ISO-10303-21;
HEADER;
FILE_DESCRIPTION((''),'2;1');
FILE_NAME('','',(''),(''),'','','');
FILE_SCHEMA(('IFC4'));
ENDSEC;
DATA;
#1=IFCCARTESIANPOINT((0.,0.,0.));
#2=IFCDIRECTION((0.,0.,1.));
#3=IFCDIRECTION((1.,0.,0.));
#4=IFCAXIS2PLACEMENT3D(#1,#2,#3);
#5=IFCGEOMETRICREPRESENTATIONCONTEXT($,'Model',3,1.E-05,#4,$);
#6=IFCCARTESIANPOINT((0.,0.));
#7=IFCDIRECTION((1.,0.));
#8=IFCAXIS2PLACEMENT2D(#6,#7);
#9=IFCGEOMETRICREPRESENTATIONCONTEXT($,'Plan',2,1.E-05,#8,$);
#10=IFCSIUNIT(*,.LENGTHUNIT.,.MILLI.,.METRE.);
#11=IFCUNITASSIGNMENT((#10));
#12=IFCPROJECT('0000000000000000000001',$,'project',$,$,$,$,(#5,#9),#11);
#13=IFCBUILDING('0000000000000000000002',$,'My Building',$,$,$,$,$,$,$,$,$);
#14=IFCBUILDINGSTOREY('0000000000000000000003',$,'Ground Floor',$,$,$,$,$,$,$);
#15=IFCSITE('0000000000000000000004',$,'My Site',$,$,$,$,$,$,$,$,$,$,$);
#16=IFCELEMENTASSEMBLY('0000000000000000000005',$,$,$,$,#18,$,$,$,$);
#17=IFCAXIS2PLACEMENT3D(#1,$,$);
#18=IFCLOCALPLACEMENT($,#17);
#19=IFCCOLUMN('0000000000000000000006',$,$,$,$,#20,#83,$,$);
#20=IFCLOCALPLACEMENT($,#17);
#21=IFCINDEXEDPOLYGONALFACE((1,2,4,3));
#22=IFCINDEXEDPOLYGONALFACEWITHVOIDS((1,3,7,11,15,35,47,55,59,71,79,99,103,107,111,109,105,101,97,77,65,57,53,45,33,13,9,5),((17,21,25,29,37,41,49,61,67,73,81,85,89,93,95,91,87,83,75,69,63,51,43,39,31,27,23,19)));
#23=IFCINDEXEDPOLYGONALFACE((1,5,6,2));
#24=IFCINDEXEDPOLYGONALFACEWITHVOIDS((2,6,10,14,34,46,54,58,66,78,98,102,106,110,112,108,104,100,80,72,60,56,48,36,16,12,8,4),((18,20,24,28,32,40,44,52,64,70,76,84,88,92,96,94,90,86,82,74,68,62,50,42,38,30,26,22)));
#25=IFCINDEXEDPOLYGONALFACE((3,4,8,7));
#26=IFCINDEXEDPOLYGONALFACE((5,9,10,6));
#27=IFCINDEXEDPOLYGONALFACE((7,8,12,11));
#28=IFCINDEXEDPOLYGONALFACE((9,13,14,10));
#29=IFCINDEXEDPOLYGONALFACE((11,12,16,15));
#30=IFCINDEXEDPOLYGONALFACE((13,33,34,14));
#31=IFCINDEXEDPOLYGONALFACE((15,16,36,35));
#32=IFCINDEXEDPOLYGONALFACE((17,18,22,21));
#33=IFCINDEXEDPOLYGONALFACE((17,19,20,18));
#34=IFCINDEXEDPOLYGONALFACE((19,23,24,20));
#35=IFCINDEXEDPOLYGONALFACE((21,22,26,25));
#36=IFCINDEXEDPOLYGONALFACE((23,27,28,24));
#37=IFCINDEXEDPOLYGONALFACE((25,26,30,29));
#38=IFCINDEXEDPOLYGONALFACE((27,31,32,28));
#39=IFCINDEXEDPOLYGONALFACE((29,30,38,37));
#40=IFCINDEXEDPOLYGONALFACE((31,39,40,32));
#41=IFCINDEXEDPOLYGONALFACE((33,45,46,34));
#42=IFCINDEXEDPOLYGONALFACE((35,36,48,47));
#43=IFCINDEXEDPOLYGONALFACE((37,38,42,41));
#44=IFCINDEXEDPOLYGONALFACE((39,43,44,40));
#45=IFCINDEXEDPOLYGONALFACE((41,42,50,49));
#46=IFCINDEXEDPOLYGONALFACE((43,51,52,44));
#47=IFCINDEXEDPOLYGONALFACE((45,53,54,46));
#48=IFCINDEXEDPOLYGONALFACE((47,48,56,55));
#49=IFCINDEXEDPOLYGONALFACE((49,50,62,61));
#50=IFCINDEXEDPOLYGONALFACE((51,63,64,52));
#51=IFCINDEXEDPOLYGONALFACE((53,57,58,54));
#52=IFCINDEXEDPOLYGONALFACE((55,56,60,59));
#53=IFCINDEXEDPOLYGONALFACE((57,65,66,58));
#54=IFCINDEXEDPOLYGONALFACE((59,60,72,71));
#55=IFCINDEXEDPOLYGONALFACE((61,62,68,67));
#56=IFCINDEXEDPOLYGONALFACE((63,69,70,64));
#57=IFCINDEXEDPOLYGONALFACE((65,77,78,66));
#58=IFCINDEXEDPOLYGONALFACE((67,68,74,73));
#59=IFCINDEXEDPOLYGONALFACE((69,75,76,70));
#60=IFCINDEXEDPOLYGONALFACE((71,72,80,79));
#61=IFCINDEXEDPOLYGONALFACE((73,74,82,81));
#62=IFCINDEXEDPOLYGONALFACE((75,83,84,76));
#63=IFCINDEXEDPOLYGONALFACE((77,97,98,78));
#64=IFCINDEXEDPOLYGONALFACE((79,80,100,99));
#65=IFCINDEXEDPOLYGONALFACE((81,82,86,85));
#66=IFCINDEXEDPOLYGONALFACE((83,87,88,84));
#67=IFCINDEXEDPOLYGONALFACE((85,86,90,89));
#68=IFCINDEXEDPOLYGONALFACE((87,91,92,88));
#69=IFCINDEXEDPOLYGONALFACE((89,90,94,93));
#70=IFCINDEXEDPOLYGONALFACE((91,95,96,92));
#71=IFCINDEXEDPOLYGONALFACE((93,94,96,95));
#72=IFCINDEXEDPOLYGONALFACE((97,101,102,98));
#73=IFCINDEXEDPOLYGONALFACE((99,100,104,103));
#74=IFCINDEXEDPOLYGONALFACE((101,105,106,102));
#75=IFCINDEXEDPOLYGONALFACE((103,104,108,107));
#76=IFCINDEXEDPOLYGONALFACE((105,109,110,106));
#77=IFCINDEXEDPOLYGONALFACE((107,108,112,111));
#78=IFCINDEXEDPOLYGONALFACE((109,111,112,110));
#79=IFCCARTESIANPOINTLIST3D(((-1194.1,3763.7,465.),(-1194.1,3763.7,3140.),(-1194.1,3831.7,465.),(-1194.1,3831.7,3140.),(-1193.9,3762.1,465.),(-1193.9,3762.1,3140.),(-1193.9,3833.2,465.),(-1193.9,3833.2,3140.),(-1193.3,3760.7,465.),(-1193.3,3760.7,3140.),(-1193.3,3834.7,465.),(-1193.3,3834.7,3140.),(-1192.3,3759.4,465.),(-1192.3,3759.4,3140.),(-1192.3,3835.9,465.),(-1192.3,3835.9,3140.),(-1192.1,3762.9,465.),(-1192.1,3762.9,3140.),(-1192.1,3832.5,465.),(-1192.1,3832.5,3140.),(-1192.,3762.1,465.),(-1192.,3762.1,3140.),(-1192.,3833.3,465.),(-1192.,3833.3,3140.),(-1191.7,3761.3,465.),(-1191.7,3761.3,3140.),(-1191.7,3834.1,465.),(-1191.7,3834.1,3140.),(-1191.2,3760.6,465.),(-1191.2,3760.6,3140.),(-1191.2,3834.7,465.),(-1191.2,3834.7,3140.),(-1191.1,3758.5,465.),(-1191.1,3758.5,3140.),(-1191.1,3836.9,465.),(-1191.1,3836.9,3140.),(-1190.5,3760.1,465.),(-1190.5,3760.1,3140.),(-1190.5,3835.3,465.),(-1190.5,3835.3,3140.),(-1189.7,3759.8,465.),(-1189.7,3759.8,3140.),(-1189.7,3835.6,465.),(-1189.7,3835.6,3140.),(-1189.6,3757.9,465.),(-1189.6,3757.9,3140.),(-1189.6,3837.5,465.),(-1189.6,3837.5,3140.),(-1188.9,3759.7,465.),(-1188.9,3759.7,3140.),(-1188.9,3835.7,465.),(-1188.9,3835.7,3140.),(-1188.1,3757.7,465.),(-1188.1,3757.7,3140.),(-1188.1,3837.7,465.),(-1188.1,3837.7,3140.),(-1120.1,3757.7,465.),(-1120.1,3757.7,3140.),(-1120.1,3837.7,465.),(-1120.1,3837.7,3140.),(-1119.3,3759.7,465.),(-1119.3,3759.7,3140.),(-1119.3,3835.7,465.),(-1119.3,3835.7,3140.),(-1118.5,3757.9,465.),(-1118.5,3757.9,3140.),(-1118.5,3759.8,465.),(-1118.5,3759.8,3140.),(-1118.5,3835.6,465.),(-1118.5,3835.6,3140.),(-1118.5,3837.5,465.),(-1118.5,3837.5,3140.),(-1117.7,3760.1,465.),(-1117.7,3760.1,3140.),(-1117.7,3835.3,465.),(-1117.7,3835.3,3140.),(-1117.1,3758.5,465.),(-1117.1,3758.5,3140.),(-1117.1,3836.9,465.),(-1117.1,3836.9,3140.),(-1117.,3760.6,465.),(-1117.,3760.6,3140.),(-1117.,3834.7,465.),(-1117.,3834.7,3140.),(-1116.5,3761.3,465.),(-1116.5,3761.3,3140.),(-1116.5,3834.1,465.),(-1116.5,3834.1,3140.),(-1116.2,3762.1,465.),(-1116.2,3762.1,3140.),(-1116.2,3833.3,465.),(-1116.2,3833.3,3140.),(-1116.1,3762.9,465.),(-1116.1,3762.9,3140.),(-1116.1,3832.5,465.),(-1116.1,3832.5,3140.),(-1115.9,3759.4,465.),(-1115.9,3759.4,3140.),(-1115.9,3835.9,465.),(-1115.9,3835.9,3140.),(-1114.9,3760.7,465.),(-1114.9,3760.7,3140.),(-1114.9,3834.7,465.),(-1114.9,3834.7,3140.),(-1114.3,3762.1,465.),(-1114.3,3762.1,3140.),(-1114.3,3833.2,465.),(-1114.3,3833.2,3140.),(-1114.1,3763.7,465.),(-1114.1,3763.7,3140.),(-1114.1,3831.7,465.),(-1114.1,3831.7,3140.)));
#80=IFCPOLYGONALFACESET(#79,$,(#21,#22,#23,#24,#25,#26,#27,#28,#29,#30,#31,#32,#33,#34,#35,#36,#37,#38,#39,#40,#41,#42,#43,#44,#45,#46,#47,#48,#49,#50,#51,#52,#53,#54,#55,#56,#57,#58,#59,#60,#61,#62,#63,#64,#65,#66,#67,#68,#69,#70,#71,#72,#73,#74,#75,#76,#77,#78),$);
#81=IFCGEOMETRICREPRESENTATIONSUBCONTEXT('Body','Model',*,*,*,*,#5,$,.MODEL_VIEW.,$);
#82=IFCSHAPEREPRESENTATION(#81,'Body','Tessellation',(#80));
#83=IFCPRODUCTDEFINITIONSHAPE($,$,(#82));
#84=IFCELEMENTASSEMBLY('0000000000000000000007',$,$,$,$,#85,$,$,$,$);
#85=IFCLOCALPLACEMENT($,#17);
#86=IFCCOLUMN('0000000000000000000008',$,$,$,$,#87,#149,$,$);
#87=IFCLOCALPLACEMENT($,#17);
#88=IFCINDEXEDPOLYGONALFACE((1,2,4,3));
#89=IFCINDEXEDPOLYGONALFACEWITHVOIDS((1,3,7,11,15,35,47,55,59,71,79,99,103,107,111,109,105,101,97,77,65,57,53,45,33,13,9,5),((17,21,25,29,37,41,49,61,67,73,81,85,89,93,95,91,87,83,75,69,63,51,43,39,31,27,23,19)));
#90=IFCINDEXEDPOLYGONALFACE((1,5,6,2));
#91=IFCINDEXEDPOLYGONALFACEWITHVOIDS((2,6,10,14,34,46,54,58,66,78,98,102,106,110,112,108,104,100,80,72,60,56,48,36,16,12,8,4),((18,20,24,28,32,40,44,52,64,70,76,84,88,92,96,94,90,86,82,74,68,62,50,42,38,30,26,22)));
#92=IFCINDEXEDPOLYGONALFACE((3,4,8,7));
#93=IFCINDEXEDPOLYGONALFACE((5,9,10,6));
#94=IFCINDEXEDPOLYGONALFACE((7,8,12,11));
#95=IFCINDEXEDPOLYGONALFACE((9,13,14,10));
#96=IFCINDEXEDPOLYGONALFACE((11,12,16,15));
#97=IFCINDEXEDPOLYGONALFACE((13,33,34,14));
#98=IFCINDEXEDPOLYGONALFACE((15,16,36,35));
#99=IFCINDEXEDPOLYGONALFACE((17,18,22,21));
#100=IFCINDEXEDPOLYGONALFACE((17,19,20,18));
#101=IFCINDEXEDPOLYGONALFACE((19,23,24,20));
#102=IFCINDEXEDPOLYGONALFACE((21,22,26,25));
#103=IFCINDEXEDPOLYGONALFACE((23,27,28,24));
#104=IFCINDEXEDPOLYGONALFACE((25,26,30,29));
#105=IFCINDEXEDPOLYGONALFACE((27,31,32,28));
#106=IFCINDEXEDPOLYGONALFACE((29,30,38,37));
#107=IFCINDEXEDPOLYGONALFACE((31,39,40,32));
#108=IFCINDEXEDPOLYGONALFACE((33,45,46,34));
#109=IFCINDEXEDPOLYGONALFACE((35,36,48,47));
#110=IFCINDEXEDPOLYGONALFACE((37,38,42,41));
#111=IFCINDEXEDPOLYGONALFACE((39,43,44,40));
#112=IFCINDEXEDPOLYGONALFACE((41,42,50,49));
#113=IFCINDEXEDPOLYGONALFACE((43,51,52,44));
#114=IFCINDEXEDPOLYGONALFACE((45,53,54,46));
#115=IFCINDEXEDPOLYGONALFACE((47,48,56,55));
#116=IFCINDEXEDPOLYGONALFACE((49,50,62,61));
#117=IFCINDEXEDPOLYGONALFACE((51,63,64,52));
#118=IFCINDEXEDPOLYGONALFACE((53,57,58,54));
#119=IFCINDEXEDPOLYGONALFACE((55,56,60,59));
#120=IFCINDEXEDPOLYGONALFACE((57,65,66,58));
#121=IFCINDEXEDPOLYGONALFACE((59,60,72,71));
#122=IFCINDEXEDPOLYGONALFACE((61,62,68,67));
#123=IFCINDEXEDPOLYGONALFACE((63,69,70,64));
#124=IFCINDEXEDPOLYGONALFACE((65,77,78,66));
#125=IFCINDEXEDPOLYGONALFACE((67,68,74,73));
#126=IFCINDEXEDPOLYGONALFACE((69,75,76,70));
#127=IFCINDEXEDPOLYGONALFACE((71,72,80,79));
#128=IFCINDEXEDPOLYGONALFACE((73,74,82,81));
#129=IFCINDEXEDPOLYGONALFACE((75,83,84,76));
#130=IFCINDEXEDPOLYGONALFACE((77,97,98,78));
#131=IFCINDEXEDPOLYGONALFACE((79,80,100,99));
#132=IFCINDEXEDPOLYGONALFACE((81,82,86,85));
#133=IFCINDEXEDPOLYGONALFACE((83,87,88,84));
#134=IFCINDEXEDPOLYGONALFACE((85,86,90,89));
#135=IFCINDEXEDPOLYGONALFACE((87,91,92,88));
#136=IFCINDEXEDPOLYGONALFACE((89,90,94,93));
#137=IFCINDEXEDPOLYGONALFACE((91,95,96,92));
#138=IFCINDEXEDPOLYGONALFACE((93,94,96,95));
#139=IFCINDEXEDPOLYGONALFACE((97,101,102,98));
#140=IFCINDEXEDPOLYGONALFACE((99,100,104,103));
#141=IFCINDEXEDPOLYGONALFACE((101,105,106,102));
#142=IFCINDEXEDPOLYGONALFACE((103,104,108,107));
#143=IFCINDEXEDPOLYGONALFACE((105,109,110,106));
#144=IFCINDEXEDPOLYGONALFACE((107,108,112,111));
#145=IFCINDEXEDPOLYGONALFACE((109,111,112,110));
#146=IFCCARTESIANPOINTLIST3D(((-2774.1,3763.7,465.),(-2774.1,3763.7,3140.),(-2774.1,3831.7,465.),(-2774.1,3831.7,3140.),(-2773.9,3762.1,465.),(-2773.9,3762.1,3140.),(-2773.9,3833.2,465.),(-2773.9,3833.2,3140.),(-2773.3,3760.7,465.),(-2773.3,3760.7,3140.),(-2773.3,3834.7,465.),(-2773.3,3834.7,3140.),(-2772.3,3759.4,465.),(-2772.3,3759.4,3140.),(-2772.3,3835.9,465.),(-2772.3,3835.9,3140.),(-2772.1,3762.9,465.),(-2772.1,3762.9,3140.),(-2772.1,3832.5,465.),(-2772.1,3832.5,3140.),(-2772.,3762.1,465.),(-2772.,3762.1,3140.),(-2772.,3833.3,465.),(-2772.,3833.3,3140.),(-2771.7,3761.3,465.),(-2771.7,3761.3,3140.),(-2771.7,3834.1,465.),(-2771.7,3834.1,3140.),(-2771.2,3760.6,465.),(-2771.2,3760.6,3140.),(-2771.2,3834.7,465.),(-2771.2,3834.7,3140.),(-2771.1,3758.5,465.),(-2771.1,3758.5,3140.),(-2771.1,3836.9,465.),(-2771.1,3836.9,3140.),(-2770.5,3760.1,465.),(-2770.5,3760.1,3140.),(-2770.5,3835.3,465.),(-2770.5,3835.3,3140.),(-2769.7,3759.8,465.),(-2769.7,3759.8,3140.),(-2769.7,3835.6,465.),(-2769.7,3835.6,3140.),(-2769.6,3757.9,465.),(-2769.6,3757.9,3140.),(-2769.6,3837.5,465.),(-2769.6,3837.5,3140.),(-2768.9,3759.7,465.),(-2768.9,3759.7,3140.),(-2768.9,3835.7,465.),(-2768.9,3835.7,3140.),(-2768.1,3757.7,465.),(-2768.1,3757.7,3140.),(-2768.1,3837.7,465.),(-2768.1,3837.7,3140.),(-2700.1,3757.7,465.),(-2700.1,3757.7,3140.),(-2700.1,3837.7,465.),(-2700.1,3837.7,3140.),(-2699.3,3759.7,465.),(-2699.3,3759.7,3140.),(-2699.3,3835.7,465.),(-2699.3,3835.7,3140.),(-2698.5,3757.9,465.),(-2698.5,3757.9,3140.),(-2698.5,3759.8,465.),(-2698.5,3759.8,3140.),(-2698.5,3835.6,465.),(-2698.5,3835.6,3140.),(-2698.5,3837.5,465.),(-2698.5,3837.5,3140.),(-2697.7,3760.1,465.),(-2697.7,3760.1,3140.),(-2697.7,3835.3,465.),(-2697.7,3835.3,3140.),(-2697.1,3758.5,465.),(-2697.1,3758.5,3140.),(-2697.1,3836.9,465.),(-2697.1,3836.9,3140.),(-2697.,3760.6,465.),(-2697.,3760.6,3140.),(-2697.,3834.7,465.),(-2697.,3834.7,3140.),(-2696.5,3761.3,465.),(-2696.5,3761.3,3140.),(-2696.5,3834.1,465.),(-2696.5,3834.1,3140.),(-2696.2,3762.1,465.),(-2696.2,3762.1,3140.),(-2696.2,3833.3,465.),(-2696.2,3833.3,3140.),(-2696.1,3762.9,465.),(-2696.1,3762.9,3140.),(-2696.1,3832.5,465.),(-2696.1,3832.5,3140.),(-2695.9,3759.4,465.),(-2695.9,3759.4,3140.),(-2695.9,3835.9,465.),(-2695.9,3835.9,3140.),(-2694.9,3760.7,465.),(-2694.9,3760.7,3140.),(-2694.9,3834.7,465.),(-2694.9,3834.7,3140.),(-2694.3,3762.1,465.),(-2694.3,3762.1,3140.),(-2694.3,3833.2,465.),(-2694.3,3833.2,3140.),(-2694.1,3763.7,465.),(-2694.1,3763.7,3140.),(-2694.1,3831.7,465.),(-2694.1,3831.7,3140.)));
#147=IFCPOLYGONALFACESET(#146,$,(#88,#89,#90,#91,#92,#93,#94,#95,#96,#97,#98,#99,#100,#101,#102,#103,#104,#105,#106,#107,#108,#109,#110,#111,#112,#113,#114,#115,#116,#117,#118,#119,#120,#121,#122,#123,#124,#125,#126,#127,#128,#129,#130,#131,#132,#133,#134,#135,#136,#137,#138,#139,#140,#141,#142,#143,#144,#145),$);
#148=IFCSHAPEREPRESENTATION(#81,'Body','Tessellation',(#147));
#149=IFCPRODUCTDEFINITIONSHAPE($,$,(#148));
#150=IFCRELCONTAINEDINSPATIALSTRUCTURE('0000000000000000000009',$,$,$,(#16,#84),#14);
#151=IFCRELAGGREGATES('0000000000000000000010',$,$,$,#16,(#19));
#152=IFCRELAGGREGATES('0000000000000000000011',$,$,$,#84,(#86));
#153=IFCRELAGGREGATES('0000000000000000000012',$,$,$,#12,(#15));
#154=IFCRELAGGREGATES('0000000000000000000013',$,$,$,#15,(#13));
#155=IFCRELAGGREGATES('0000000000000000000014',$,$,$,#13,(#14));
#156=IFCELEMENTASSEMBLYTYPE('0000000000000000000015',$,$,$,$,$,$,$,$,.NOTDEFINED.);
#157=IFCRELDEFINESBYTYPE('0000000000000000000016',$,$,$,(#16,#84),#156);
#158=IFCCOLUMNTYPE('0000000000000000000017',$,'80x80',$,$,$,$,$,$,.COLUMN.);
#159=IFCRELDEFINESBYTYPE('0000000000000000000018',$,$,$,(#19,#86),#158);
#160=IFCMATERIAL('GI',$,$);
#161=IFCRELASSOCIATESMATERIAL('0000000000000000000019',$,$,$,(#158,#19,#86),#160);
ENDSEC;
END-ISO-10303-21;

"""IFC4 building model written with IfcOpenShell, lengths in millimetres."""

from ifc_helpers import new_model, si_unit, frame, origin_with_axes, origin_2d_with_axis, place, context, subcontext, project, spatial, hollow_rectangle, extrude, material, material_profile, profile_set, profile_usage, type_object, element, aggregate, save


model = new_model("IFC4")

# Units and contexts
model_context = context("Model", 3, precision=1e-05, world=origin_with_axes())
plan_context = context("Plan", 2, precision=1e-05, world=origin_2d_with_axis())
body_context = subcontext(model_context, "Body", "Model", "MODEL_VIEW")
ifc_project = project(units=[si_unit("LENGTHUNIT", "METRE", prefix="MILLI")], contexts=[model_context, plan_context])

# Site, building, storey
site = spatial("IfcSite", under=ifc_project, Name="My Site")
building = spatial("IfcBuilding", under=site, Name="My Building")
storey = spatial("IfcBuildingStorey", under=building, Name="Ground Floor")

# Element assemblies, columns
element_assembly_type_1 = type_object("IfcElementAssemblyType", PredefinedType="NOTDEFINED")
ifc_material = material(Name="GI")
ifc_material_profile_1 = material_profile(ifc_material, hollow_rectangle(XDim=80.0, YDim=80.0, WallThickness=2.0, InnerFilletRadius=3.2, OuterFilletRadius=6.0))
ifc_profile_set_1 = profile_set([ifc_material_profile_1], Name="80x80 GI Rectangular Hollow")
column_type = type_object("IfcColumnType", Name="80x80", PredefinedType="COLUMN", material=ifc_profile_set_1)
assembly_1_placement = place(None, frame((-1154.1, 3797.7, 465.0), z_axis=(0.0, 0.0, 1.0), x_axis=(1.0, 0.0, 0.0)))
assembly_1 = element("IfcElementAssembly", 1, at=assembly_1_placement, inside=storey, type_object=element_assembly_type_1)
ifc_profile_usage_1 = profile_usage(ifc_profile_set_1)
column_1_placement = place(assembly_1_placement, origin_with_axes())
column_1 = element("IfcColumn", 2, at=column_1_placement, type_object=column_type, material=ifc_profile_usage_1, context=body_context, shape_type="SweptSolid", body=[
    extrude(hollow_rectangle(XDim=80.0, YDim=80.0, WallThickness=2.0, InnerFilletRadius=3.2, OuterFilletRadius=6.0), origin_with_axes(), (0.0, 0.0, 1.0), 2675.0),
])
aggregate(assembly_1, [column_1])
assembly_2_placement = place(None, frame((-2734.1, 3797.7, 465.0), z_axis=(0.0, 0.0, 1.0), x_axis=(1.0, 0.0, 0.0)))
assembly_2 = element("IfcElementAssembly", 3, at=assembly_2_placement, inside=storey, type_object=element_assembly_type_1)
ifc_profile_usage_2 = profile_usage(ifc_profile_set_1)
column_2_placement = place(assembly_2_placement, origin_with_axes())
column_2 = element("IfcColumn", 4, at=column_2_placement, type_object=column_type, material=ifc_profile_usage_2, context=body_context, shape_type="SweptSolid", body=[
    extrude(hollow_rectangle(XDim=80.0, YDim=80.0, WallThickness=2.0, InnerFilletRadius=3.2, OuterFilletRadius=6.0), origin_with_axes(), (0.0, 0.0, 1.0), 2675.0),
])
aggregate(assembly_2, [column_2])

save(model, "model.ifc")
